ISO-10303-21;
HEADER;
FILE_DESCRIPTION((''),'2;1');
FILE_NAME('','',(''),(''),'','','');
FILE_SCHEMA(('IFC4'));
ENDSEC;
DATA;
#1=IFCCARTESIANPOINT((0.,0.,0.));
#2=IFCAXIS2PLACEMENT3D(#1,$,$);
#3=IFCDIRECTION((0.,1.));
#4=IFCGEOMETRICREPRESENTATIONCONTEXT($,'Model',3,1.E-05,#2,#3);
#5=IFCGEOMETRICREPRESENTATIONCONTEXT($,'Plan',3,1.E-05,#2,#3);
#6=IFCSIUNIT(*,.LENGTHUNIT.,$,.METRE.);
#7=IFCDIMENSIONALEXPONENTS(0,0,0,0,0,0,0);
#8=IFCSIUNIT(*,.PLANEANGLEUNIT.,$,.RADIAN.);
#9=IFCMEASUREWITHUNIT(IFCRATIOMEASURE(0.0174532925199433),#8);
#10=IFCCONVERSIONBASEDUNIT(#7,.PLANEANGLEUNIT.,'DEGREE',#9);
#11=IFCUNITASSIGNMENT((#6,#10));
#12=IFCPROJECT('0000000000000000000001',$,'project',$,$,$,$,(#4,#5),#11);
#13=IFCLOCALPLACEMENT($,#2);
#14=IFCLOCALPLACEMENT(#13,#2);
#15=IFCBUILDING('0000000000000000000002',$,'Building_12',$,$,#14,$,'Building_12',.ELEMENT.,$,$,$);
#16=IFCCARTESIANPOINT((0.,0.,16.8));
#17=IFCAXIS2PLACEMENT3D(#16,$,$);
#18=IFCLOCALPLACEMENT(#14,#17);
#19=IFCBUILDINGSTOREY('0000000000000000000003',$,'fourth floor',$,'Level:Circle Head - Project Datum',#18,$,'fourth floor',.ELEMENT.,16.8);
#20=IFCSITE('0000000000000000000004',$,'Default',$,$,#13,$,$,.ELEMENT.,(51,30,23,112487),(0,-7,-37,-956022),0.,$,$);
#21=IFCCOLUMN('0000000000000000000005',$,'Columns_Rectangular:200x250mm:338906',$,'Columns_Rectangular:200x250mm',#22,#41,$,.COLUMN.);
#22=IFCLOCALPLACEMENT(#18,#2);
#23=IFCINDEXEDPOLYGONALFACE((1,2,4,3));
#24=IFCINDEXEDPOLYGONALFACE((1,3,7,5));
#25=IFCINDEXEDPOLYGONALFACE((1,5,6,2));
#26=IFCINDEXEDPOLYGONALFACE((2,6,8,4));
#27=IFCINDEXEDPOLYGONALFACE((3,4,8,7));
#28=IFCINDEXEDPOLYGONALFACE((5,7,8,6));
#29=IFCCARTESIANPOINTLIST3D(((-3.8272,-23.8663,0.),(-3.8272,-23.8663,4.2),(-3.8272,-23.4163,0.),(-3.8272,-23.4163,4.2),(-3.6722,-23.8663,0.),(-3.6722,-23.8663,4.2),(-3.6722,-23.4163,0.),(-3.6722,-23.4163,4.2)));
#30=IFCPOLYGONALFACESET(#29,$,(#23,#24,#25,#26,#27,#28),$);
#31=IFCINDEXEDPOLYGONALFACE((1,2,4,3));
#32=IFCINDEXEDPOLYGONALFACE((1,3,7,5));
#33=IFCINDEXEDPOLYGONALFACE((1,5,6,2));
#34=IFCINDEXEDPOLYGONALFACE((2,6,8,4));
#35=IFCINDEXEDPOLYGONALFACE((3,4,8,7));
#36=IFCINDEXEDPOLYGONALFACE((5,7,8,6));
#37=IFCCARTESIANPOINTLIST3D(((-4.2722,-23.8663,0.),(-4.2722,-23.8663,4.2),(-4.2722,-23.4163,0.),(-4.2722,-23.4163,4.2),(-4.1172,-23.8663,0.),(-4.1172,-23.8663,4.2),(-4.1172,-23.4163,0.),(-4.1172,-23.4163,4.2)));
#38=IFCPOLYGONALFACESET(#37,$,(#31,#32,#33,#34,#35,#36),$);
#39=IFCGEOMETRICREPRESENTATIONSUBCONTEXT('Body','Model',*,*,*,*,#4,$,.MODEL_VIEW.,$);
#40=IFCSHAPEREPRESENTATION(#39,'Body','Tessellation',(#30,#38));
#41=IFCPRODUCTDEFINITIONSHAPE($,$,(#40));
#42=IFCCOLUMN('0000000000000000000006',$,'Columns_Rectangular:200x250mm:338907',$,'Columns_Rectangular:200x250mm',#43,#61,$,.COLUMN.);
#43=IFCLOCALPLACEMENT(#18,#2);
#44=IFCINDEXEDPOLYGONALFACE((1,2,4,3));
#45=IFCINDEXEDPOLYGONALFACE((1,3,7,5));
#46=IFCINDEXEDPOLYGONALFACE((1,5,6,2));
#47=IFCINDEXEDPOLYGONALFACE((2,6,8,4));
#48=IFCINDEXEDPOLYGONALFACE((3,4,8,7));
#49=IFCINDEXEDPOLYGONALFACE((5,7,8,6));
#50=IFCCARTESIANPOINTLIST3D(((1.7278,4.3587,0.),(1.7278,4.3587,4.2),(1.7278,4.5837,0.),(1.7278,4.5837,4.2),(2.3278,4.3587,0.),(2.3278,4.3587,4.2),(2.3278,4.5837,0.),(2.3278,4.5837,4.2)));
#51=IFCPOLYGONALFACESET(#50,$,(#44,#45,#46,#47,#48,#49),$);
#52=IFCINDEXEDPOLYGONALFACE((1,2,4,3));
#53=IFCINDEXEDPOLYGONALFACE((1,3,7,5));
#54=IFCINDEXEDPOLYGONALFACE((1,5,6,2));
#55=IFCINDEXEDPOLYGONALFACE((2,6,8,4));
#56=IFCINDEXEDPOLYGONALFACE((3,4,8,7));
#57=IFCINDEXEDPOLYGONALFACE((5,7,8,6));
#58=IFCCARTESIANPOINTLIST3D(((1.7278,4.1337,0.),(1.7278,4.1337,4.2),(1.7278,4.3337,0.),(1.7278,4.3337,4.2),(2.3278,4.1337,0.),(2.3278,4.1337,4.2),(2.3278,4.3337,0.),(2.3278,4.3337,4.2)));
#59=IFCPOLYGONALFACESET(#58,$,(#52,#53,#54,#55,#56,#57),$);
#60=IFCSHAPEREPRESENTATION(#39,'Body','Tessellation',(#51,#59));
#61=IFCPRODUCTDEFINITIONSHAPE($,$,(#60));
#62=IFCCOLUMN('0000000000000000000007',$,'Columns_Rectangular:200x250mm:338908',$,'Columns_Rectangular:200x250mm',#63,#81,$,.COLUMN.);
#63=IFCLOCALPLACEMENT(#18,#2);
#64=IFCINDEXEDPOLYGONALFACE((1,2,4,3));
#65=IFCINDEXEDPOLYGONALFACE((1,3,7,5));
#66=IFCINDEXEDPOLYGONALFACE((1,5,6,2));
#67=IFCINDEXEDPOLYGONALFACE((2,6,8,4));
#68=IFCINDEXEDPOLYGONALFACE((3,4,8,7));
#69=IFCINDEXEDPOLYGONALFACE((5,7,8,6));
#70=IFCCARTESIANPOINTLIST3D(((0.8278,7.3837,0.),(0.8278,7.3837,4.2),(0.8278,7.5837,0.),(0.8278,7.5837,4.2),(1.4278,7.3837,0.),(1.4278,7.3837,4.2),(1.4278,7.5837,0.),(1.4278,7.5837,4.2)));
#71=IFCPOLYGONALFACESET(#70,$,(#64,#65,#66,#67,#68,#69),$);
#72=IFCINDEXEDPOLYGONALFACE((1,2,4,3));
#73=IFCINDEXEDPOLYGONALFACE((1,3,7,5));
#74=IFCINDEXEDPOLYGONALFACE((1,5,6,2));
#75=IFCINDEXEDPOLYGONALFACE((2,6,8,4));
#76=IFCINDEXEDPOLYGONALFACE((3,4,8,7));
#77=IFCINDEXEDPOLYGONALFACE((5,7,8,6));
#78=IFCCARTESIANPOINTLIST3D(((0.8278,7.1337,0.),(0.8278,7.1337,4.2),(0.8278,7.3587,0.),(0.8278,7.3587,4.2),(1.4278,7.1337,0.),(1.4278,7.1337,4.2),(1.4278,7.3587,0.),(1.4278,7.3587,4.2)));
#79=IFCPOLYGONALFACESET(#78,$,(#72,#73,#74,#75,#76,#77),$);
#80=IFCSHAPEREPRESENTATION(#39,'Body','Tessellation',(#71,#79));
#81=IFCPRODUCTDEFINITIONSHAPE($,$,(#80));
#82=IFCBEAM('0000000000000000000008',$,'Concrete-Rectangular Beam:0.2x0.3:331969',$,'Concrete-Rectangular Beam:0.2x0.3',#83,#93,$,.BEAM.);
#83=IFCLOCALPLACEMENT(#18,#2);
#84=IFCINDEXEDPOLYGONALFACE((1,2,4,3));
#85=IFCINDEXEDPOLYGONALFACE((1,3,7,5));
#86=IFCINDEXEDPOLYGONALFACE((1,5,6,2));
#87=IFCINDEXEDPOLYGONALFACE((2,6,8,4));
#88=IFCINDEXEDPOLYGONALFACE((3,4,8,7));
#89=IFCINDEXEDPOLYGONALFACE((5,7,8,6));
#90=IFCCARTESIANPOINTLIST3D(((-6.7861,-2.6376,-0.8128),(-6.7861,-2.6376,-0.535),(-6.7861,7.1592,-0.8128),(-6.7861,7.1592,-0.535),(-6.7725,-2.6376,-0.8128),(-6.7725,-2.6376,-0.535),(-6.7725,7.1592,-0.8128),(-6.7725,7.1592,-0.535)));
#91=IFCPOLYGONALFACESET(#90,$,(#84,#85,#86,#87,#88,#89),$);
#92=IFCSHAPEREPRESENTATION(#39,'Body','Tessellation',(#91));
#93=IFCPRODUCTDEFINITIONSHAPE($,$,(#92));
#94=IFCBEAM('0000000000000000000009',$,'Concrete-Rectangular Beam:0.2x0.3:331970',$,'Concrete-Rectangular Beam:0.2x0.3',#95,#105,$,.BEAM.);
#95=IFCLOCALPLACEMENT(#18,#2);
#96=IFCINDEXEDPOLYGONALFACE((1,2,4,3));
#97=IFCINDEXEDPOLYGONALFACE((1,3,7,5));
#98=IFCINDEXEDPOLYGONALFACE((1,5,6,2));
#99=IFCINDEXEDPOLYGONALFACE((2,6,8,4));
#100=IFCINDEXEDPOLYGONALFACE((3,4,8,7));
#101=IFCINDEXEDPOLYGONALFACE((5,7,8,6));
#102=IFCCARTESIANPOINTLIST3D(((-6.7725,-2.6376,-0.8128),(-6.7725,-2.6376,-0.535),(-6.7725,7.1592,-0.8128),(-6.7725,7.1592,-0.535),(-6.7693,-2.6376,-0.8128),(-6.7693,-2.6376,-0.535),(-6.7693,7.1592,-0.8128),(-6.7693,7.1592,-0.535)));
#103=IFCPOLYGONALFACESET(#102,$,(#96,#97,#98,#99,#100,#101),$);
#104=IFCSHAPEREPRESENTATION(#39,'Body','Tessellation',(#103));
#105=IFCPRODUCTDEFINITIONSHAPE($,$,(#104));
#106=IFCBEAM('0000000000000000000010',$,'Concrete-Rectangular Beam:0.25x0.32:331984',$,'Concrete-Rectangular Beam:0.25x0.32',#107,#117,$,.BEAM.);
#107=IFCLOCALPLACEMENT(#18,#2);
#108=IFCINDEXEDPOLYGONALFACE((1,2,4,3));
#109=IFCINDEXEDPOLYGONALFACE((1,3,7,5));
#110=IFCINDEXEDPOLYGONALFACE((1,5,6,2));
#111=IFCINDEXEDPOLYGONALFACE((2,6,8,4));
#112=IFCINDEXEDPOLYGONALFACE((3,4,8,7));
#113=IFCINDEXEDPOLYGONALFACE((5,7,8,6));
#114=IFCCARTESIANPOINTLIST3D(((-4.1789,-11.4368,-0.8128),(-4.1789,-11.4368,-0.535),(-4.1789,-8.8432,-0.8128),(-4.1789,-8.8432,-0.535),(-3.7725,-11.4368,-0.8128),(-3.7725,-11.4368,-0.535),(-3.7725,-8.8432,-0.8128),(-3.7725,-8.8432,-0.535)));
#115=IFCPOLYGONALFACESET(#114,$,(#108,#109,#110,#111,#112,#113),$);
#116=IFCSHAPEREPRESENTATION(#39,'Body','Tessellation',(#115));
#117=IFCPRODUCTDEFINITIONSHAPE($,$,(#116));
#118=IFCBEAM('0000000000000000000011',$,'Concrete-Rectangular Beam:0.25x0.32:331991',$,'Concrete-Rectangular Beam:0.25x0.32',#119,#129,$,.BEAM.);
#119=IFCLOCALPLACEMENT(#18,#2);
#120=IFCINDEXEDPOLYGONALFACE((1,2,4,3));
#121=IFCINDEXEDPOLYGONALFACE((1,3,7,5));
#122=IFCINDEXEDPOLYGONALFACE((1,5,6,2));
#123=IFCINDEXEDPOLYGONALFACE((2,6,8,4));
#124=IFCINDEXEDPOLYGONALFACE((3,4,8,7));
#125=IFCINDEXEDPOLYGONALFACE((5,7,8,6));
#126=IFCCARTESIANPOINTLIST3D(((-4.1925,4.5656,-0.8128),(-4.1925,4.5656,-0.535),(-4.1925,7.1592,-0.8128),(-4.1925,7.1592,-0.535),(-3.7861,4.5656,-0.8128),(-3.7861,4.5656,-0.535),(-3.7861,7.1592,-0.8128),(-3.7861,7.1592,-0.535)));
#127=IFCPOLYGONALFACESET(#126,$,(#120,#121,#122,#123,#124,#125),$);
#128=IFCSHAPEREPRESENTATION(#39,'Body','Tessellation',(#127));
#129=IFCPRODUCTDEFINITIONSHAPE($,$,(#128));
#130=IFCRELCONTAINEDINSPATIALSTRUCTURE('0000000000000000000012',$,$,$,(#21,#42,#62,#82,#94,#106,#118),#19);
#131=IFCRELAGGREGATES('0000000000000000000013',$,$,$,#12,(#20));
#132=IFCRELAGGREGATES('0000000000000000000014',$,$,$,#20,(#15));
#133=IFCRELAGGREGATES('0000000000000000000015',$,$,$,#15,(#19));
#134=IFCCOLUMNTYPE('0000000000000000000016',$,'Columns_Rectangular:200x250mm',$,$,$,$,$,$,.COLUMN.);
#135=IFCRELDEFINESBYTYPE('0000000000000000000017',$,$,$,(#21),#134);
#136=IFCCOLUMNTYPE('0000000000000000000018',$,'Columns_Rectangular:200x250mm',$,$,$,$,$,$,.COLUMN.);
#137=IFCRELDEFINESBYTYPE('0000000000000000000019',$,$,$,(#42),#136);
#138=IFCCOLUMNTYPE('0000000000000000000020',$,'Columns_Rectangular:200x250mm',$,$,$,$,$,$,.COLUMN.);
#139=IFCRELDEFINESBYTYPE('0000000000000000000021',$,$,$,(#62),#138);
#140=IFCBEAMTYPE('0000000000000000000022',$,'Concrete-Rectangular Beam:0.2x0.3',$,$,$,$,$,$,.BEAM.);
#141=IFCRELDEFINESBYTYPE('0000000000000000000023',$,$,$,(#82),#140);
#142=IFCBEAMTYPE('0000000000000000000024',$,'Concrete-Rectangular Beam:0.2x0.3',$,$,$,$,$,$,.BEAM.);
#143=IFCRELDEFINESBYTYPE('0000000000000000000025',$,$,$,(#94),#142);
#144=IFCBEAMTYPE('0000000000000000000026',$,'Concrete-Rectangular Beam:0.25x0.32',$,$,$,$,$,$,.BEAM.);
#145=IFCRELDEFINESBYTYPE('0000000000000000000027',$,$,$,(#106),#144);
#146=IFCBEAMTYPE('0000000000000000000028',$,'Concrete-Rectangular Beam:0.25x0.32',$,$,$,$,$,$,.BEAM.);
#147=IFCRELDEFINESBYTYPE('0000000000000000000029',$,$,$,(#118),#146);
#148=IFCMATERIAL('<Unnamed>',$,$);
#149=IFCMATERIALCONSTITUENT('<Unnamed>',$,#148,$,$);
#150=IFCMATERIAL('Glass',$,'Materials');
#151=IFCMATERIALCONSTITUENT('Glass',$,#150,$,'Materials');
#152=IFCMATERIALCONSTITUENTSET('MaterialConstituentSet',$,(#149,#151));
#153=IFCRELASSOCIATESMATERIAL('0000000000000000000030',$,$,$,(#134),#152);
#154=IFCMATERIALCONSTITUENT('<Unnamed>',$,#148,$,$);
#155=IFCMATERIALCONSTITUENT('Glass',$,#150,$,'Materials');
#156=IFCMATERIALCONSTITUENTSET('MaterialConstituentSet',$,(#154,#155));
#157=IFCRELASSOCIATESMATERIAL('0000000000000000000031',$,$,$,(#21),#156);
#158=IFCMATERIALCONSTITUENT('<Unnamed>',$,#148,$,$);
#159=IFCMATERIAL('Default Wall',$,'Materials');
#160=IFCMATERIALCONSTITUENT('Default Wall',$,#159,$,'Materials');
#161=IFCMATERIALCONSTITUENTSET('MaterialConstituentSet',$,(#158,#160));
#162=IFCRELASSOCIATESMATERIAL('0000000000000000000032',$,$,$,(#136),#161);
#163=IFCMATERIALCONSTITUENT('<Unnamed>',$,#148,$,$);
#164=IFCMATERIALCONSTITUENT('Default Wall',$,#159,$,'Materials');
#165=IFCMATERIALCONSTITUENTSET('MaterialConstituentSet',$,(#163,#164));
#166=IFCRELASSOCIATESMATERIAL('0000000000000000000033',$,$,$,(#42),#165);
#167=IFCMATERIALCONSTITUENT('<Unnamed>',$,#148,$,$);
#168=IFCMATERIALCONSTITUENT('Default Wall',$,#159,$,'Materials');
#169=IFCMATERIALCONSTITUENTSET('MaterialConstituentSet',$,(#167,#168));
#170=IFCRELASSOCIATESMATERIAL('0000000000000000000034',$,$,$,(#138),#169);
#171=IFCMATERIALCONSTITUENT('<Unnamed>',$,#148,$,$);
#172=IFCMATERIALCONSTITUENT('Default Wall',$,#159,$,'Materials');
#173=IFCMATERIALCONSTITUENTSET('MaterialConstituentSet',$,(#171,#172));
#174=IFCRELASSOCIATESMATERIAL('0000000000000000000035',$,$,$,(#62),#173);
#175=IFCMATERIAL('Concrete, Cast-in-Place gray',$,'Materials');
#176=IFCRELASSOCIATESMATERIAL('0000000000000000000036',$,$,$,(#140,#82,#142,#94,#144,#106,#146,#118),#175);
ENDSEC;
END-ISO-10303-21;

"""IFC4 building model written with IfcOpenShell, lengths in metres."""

from ifc_helpers import new_model, entity, si_unit, converted_unit, direction, frame, origin, place, context, subcontext, project, spatial, indexed_curve, outline, extrude, source, transform, mapped, material, constituent, constituent_set, type_object, type_shapes, element, save


model = new_model("IFC4")

# Units and contexts
model_context = context("Model", 3, precision=1e-05, world=origin(), true_north=direction((0.0, 1.0)))
plan_context = context("Plan", 3, precision=1e-05, world=origin(), true_north=direction((0.0, 1.0)))
body_context = subcontext(model_context, "Body", "Model", "MODEL_VIEW")
ifc_project = project(units=[si_unit("LENGTHUNIT", "METRE"), converted_unit("PLANEANGLEUNIT", "DEGREE", entity("IfcRatioMeasure", 0.0174532925199433), si_unit("PLANEANGLEUNIT", "RADIAN"), dimensions=[0, 0, 0, 0, 0, 0, 0])], contexts=[model_context, plan_context])

# Site, building, storey
site_placement = place(None, origin())
site = spatial("IfcSite", under=ifc_project, at=site_placement, Name="Default", CompositionType="ELEMENT", RefLatitude=(51, 30, 23, 112487), RefLongitude=(0, -7, -37, -956022), RefElevation=0.0)
building_placement = place(site_placement, origin())
building = spatial("IfcBuilding", under=site, at=building_placement, Name="Building_12", LongName="Building_12", CompositionType="ELEMENT")
storey_placement = place(building_placement, frame((0.0, 0.0, 16.8)))
storey = spatial("IfcBuildingStorey", under=building, at=storey_placement, Name="fourth floor", ObjectType="Level:Circle Head - Project Datum", LongName="fourth floor", CompositionType="ELEMENT", Elevation=16.8)

# Columns
ifc_material_1 = material(Name="<Unnamed>")
ifc_material_2 = material(Name="Default Wall", Category="Materials")
ifc_material_3 = material(Name="Glass", Category="Materials")
ifc_constituent_1 = constituent(ifc_material_1, Name="<Unnamed>")
ifc_constituent_2 = constituent(ifc_material_3, Name="Glass", Category="Materials")
ifc_constituent_set_1 = constituent_set(constituents=[ifc_constituent_1, ifc_constituent_2], Name="MaterialConstituentSet")
ifc_constituent_3 = constituent(ifc_material_1, Name="<Unnamed>")
ifc_constituent_4 = constituent(ifc_material_3, Name="Glass", Category="Materials")
ifc_constituent_set_2 = constituent_set(constituents=[ifc_constituent_3, ifc_constituent_4], Name="MaterialConstituentSet")
column_type_1 = type_object("IfcColumnType", Name="Columns_Rectangular:200x250mm", PredefinedType="COLUMN", material=ifc_constituent_set_2)
shared_shape_1 = source(origin(), body_context, "Body", "SweptSolid", [
    extrude(outline(indexed_curve([(-0.225, -0.0775), (0.225, -0.0775), (0.225, 0.0775), (-0.225, 0.0775), (-0.225, -0.0775)], self_intersect=False)), frame((-3.7497, -23.6413, 16.8), z_axis=(0.0, 0.0, 1.0), x_axis=(0.0, -1.0, 0.0)), (0.0, 0.0, 1.0), 4.2),
    extrude(outline(indexed_curve([(-0.225, -0.0775), (0.225, -0.0775), (0.225, 0.0775), (-0.225, 0.0775), (-0.225, -0.0775)], self_intersect=False)), frame((-4.1947, -23.6413, 16.8), z_axis=(0.0, 0.0, 1.0), x_axis=(0.0, -1.0, 0.0)), (0.0, 0.0, 1.0), 4.2),
])
type_shapes(column_type_1, [shared_shape_1])
column_1_placement = place(storey_placement, frame((0.0, 0.0, -16.8)))
element("IfcColumn", 1, at=column_1_placement, inside=storey, type_object=column_type_1, material=ifc_constituent_set_1, Name="Columns_Rectangular:200x250mm:338906", ObjectType="Columns_Rectangular:200x250mm", PredefinedType="COLUMN", context=body_context, shape_type="MappedRepresentation", body=[
    mapped(shared_shape_1, transform((0.0, 0.0, 0.0), scale=1.0)),
])
ifc_constituent_5 = constituent(ifc_material_1, Name="<Unnamed>")
ifc_constituent_6 = constituent(ifc_material_2, Name="Default Wall", Category="Materials")
ifc_constituent_set_3 = constituent_set(constituents=[ifc_constituent_5, ifc_constituent_6], Name="MaterialConstituentSet")
ifc_constituent_7 = constituent(ifc_material_1, Name="<Unnamed>")
ifc_constituent_8 = constituent(ifc_material_2, Name="Default Wall", Category="Materials")
ifc_constituent_set_4 = constituent_set(constituents=[ifc_constituent_7, ifc_constituent_8], Name="MaterialConstituentSet")
column_type_2 = type_object("IfcColumnType", Name="Columns_Rectangular:200x250mm", PredefinedType="COLUMN", material=ifc_constituent_set_4)
shared_shape_2 = source(origin(), body_context, "Body", "SweptSolid", [
    extrude(outline(indexed_curve([(-0.1125, -0.3), (0.1125, -0.3), (0.1125, 0.3), (-0.1125, 0.3), (-0.1125, -0.3)], self_intersect=False)), frame((2.0278, 4.4712, 16.8), z_axis=(0.0, 0.0, 1.0), x_axis=(0.0, -1.0, 0.0)), (0.0, 0.0, 1.0), 4.2),
    extrude(outline(indexed_curve([(-0.1, -0.3), (0.1, -0.3), (0.1, 0.3), (-0.1, 0.3), (-0.1, -0.3)], self_intersect=False)), frame((2.0278, 4.2337, 16.8), z_axis=(0.0, 0.0, 1.0), x_axis=(0.0, -1.0, 0.0)), (0.0, 0.0, 1.0), 4.2),
])
type_shapes(column_type_2, [shared_shape_2])
column_2_placement = place(storey_placement, frame((0.0, 0.0, -16.8)))
element("IfcColumn", 2, at=column_2_placement, inside=storey, type_object=column_type_2, material=ifc_constituent_set_3, Name="Columns_Rectangular:200x250mm:338907", ObjectType="Columns_Rectangular:200x250mm", PredefinedType="COLUMN", context=body_context, shape_type="MappedRepresentation", body=[
    mapped(shared_shape_2, transform((0.0, 0.0, 0.0), scale=1.0)),
])
ifc_constituent_9 = constituent(ifc_material_1, Name="<Unnamed>")
ifc_constituent_10 = constituent(ifc_material_2, Name="Default Wall", Category="Materials")
ifc_constituent_set_5 = constituent_set(constituents=[ifc_constituent_9, ifc_constituent_10], Name="MaterialConstituentSet")
ifc_constituent_11 = constituent(ifc_material_1, Name="<Unnamed>")
ifc_constituent_12 = constituent(ifc_material_2, Name="Default Wall", Category="Materials")
ifc_constituent_set_6 = constituent_set(constituents=[ifc_constituent_11, ifc_constituent_12], Name="MaterialConstituentSet")
column_type_3 = type_object("IfcColumnType", Name="Columns_Rectangular:200x250mm", PredefinedType="COLUMN", material=ifc_constituent_set_6)
shared_shape_3 = source(origin(), body_context, "Body", "SweptSolid", [
    extrude(outline(indexed_curve([(-0.1, -0.3), (0.1, -0.3), (0.1, 0.3), (-0.1, 0.3), (-0.1, -0.3)], self_intersect=False)), frame((1.1278, 7.4837, 16.8), z_axis=(0.0, 0.0, 1.0), x_axis=(0.0, -1.0, 0.0)), (0.0, 0.0, 1.0), 4.2),
    extrude(outline(indexed_curve([(-0.1125, -0.3), (0.1125, -0.3), (0.1125, 0.3), (-0.1125, 0.3), (-0.1125, -0.3)], self_intersect=False)), frame((1.1278, 7.2462, 16.8), z_axis=(0.0, 0.0, 1.0), x_axis=(0.0, -1.0, 0.0)), (0.0, 0.0, 1.0), 4.2),
])
type_shapes(column_type_3, [shared_shape_3])
column_3_placement = place(storey_placement, frame((0.0, 0.0, -16.8)))
element("IfcColumn", 3, at=column_3_placement, inside=storey, type_object=column_type_3, material=ifc_constituent_set_5, Name="Columns_Rectangular:200x250mm:338908", ObjectType="Columns_Rectangular:200x250mm", PredefinedType="COLUMN", context=body_context, shape_type="MappedRepresentation", body=[
    mapped(shared_shape_3, transform((0.0, 0.0, 0.0), scale=1.0)),
])

# Beams
ifc_material_4 = material(Name="Concrete, Cast-in-Place gray", Category="Materials")
beam_type_1 = type_object("IfcBeamType", Name="Concrete-Rectangular Beam:0.2x0.3", PredefinedType="BEAM", material=ifc_material_4)
shared_shape_4 = source(origin(), body_context, "Body", "SweptSolid", [
    extrude(outline(indexed_curve([(-0.0068, -0.1389), (0.0068, -0.1389), (0.0068, 0.1389), (-0.0068, 0.1389), (-0.0068, -0.1389)], self_intersect=False)), frame((-6.7793, 7.1592, 16.1261), z_axis=(0.0, -1.0, 0.0), x_axis=(-1.0, 0.0, 0.0)), (0.0, 0.0, 1.0), 9.7968),
])
type_shapes(beam_type_1, [shared_shape_4])
beam_1_placement = place(storey_placement, frame((0.0, 0.0, -16.8)))
element("IfcBeam", 4, at=beam_1_placement, inside=storey, type_object=beam_type_1, material=ifc_material_4, Name="Concrete-Rectangular Beam:0.2x0.3:331969", ObjectType="Concrete-Rectangular Beam:0.2x0.3", PredefinedType="BEAM", context=body_context, shape_type="MappedRepresentation", body=[
    mapped(shared_shape_4, transform((0.0, 0.0, 0.0), scale=1.0)),
])
beam_type_2 = type_object("IfcBeamType", Name="Concrete-Rectangular Beam:0.2x0.3", PredefinedType="BEAM", material=ifc_material_4)
shared_shape_5 = source(origin(), body_context, "Body", "SweptSolid", [
    extrude(outline(indexed_curve([(-0.0016, -0.1389), (0.0016, -0.1389), (0.0016, 0.1389), (-0.0016, 0.1389), (-0.0016, -0.1389)], self_intersect=False)), frame((-6.7709, 7.1592, 16.1261), z_axis=(0.0, -1.0, 0.0), x_axis=(-1.0, 0.0, 0.0)), (0.0, 0.0, 1.0), 9.7968),
])
type_shapes(beam_type_2, [shared_shape_5])
beam_2_placement = place(storey_placement, frame((0.0, 0.0, -16.8)))
element("IfcBeam", 5, at=beam_2_placement, inside=storey, type_object=beam_type_2, material=ifc_material_4, Name="Concrete-Rectangular Beam:0.2x0.3:331970", ObjectType="Concrete-Rectangular Beam:0.2x0.3", PredefinedType="BEAM", context=body_context, shape_type="MappedRepresentation", body=[
    mapped(shared_shape_5, transform((0.0, 0.0, 0.0), scale=1.0)),
])
beam_type_3 = type_object("IfcBeamType", Name="Concrete-Rectangular Beam:0.25x0.32", PredefinedType="BEAM", material=ifc_material_4)
shared_shape_6 = source(origin(), body_context, "Body", "SweptSolid", [
    extrude(outline(indexed_curve([(-0.2032, -0.1389), (0.2032, -0.1389), (0.2032, 0.1389), (-0.2032, 0.1389), (-0.2032, -0.1389)], self_intersect=False)), frame((-3.9757, -8.8432, 16.1261), z_axis=(0.0, -1.0, 0.0), x_axis=(-1.0, 0.0, 0.0)), (0.0, 0.0, 1.0), 2.5936),
])
type_shapes(beam_type_3, [shared_shape_6])
beam_3_placement = place(storey_placement, frame((0.0, 0.0, -16.8)))
element("IfcBeam", 6, at=beam_3_placement, inside=storey, type_object=beam_type_3, material=ifc_material_4, Name="Concrete-Rectangular Beam:0.25x0.32:331984", ObjectType="Concrete-Rectangular Beam:0.25x0.32", PredefinedType="BEAM", context=body_context, shape_type="MappedRepresentation", body=[
    mapped(shared_shape_6, transform((0.0, 0.0, 0.0), scale=1.0)),
])
beam_type_4 = type_object("IfcBeamType", Name="Concrete-Rectangular Beam:0.25x0.32", PredefinedType="BEAM", material=ifc_material_4)
shared_shape_7 = source(origin(), body_context, "Body", "SweptSolid", [
    extrude(outline(indexed_curve([(-0.2032, -0.1389), (0.2032, -0.1389), (0.2032, 0.1389), (-0.2032, 0.1389), (-0.2032, -0.1389)], self_intersect=False)), frame((-3.9893, 7.1592, 16.1261), z_axis=(0.0, -1.0, 0.0), x_axis=(-1.0, 0.0, 0.0)), (0.0, 0.0, 1.0), 2.5936),
])
type_shapes(beam_type_4, [shared_shape_7])
beam_4_placement = place(storey_placement, frame((0.0, 0.0, -16.8)))
element("IfcBeam", 7, at=beam_4_placement, inside=storey, type_object=beam_type_4, material=ifc_material_4, Name="Concrete-Rectangular Beam:0.25x0.32:331991", ObjectType="Concrete-Rectangular Beam:0.25x0.32", PredefinedType="BEAM", context=body_context, shape_type="MappedRepresentation", body=[
    mapped(shared_shape_7, transform((0.0, 0.0, 0.0), scale=1.0)),
])

save(model, "model.ifc")
